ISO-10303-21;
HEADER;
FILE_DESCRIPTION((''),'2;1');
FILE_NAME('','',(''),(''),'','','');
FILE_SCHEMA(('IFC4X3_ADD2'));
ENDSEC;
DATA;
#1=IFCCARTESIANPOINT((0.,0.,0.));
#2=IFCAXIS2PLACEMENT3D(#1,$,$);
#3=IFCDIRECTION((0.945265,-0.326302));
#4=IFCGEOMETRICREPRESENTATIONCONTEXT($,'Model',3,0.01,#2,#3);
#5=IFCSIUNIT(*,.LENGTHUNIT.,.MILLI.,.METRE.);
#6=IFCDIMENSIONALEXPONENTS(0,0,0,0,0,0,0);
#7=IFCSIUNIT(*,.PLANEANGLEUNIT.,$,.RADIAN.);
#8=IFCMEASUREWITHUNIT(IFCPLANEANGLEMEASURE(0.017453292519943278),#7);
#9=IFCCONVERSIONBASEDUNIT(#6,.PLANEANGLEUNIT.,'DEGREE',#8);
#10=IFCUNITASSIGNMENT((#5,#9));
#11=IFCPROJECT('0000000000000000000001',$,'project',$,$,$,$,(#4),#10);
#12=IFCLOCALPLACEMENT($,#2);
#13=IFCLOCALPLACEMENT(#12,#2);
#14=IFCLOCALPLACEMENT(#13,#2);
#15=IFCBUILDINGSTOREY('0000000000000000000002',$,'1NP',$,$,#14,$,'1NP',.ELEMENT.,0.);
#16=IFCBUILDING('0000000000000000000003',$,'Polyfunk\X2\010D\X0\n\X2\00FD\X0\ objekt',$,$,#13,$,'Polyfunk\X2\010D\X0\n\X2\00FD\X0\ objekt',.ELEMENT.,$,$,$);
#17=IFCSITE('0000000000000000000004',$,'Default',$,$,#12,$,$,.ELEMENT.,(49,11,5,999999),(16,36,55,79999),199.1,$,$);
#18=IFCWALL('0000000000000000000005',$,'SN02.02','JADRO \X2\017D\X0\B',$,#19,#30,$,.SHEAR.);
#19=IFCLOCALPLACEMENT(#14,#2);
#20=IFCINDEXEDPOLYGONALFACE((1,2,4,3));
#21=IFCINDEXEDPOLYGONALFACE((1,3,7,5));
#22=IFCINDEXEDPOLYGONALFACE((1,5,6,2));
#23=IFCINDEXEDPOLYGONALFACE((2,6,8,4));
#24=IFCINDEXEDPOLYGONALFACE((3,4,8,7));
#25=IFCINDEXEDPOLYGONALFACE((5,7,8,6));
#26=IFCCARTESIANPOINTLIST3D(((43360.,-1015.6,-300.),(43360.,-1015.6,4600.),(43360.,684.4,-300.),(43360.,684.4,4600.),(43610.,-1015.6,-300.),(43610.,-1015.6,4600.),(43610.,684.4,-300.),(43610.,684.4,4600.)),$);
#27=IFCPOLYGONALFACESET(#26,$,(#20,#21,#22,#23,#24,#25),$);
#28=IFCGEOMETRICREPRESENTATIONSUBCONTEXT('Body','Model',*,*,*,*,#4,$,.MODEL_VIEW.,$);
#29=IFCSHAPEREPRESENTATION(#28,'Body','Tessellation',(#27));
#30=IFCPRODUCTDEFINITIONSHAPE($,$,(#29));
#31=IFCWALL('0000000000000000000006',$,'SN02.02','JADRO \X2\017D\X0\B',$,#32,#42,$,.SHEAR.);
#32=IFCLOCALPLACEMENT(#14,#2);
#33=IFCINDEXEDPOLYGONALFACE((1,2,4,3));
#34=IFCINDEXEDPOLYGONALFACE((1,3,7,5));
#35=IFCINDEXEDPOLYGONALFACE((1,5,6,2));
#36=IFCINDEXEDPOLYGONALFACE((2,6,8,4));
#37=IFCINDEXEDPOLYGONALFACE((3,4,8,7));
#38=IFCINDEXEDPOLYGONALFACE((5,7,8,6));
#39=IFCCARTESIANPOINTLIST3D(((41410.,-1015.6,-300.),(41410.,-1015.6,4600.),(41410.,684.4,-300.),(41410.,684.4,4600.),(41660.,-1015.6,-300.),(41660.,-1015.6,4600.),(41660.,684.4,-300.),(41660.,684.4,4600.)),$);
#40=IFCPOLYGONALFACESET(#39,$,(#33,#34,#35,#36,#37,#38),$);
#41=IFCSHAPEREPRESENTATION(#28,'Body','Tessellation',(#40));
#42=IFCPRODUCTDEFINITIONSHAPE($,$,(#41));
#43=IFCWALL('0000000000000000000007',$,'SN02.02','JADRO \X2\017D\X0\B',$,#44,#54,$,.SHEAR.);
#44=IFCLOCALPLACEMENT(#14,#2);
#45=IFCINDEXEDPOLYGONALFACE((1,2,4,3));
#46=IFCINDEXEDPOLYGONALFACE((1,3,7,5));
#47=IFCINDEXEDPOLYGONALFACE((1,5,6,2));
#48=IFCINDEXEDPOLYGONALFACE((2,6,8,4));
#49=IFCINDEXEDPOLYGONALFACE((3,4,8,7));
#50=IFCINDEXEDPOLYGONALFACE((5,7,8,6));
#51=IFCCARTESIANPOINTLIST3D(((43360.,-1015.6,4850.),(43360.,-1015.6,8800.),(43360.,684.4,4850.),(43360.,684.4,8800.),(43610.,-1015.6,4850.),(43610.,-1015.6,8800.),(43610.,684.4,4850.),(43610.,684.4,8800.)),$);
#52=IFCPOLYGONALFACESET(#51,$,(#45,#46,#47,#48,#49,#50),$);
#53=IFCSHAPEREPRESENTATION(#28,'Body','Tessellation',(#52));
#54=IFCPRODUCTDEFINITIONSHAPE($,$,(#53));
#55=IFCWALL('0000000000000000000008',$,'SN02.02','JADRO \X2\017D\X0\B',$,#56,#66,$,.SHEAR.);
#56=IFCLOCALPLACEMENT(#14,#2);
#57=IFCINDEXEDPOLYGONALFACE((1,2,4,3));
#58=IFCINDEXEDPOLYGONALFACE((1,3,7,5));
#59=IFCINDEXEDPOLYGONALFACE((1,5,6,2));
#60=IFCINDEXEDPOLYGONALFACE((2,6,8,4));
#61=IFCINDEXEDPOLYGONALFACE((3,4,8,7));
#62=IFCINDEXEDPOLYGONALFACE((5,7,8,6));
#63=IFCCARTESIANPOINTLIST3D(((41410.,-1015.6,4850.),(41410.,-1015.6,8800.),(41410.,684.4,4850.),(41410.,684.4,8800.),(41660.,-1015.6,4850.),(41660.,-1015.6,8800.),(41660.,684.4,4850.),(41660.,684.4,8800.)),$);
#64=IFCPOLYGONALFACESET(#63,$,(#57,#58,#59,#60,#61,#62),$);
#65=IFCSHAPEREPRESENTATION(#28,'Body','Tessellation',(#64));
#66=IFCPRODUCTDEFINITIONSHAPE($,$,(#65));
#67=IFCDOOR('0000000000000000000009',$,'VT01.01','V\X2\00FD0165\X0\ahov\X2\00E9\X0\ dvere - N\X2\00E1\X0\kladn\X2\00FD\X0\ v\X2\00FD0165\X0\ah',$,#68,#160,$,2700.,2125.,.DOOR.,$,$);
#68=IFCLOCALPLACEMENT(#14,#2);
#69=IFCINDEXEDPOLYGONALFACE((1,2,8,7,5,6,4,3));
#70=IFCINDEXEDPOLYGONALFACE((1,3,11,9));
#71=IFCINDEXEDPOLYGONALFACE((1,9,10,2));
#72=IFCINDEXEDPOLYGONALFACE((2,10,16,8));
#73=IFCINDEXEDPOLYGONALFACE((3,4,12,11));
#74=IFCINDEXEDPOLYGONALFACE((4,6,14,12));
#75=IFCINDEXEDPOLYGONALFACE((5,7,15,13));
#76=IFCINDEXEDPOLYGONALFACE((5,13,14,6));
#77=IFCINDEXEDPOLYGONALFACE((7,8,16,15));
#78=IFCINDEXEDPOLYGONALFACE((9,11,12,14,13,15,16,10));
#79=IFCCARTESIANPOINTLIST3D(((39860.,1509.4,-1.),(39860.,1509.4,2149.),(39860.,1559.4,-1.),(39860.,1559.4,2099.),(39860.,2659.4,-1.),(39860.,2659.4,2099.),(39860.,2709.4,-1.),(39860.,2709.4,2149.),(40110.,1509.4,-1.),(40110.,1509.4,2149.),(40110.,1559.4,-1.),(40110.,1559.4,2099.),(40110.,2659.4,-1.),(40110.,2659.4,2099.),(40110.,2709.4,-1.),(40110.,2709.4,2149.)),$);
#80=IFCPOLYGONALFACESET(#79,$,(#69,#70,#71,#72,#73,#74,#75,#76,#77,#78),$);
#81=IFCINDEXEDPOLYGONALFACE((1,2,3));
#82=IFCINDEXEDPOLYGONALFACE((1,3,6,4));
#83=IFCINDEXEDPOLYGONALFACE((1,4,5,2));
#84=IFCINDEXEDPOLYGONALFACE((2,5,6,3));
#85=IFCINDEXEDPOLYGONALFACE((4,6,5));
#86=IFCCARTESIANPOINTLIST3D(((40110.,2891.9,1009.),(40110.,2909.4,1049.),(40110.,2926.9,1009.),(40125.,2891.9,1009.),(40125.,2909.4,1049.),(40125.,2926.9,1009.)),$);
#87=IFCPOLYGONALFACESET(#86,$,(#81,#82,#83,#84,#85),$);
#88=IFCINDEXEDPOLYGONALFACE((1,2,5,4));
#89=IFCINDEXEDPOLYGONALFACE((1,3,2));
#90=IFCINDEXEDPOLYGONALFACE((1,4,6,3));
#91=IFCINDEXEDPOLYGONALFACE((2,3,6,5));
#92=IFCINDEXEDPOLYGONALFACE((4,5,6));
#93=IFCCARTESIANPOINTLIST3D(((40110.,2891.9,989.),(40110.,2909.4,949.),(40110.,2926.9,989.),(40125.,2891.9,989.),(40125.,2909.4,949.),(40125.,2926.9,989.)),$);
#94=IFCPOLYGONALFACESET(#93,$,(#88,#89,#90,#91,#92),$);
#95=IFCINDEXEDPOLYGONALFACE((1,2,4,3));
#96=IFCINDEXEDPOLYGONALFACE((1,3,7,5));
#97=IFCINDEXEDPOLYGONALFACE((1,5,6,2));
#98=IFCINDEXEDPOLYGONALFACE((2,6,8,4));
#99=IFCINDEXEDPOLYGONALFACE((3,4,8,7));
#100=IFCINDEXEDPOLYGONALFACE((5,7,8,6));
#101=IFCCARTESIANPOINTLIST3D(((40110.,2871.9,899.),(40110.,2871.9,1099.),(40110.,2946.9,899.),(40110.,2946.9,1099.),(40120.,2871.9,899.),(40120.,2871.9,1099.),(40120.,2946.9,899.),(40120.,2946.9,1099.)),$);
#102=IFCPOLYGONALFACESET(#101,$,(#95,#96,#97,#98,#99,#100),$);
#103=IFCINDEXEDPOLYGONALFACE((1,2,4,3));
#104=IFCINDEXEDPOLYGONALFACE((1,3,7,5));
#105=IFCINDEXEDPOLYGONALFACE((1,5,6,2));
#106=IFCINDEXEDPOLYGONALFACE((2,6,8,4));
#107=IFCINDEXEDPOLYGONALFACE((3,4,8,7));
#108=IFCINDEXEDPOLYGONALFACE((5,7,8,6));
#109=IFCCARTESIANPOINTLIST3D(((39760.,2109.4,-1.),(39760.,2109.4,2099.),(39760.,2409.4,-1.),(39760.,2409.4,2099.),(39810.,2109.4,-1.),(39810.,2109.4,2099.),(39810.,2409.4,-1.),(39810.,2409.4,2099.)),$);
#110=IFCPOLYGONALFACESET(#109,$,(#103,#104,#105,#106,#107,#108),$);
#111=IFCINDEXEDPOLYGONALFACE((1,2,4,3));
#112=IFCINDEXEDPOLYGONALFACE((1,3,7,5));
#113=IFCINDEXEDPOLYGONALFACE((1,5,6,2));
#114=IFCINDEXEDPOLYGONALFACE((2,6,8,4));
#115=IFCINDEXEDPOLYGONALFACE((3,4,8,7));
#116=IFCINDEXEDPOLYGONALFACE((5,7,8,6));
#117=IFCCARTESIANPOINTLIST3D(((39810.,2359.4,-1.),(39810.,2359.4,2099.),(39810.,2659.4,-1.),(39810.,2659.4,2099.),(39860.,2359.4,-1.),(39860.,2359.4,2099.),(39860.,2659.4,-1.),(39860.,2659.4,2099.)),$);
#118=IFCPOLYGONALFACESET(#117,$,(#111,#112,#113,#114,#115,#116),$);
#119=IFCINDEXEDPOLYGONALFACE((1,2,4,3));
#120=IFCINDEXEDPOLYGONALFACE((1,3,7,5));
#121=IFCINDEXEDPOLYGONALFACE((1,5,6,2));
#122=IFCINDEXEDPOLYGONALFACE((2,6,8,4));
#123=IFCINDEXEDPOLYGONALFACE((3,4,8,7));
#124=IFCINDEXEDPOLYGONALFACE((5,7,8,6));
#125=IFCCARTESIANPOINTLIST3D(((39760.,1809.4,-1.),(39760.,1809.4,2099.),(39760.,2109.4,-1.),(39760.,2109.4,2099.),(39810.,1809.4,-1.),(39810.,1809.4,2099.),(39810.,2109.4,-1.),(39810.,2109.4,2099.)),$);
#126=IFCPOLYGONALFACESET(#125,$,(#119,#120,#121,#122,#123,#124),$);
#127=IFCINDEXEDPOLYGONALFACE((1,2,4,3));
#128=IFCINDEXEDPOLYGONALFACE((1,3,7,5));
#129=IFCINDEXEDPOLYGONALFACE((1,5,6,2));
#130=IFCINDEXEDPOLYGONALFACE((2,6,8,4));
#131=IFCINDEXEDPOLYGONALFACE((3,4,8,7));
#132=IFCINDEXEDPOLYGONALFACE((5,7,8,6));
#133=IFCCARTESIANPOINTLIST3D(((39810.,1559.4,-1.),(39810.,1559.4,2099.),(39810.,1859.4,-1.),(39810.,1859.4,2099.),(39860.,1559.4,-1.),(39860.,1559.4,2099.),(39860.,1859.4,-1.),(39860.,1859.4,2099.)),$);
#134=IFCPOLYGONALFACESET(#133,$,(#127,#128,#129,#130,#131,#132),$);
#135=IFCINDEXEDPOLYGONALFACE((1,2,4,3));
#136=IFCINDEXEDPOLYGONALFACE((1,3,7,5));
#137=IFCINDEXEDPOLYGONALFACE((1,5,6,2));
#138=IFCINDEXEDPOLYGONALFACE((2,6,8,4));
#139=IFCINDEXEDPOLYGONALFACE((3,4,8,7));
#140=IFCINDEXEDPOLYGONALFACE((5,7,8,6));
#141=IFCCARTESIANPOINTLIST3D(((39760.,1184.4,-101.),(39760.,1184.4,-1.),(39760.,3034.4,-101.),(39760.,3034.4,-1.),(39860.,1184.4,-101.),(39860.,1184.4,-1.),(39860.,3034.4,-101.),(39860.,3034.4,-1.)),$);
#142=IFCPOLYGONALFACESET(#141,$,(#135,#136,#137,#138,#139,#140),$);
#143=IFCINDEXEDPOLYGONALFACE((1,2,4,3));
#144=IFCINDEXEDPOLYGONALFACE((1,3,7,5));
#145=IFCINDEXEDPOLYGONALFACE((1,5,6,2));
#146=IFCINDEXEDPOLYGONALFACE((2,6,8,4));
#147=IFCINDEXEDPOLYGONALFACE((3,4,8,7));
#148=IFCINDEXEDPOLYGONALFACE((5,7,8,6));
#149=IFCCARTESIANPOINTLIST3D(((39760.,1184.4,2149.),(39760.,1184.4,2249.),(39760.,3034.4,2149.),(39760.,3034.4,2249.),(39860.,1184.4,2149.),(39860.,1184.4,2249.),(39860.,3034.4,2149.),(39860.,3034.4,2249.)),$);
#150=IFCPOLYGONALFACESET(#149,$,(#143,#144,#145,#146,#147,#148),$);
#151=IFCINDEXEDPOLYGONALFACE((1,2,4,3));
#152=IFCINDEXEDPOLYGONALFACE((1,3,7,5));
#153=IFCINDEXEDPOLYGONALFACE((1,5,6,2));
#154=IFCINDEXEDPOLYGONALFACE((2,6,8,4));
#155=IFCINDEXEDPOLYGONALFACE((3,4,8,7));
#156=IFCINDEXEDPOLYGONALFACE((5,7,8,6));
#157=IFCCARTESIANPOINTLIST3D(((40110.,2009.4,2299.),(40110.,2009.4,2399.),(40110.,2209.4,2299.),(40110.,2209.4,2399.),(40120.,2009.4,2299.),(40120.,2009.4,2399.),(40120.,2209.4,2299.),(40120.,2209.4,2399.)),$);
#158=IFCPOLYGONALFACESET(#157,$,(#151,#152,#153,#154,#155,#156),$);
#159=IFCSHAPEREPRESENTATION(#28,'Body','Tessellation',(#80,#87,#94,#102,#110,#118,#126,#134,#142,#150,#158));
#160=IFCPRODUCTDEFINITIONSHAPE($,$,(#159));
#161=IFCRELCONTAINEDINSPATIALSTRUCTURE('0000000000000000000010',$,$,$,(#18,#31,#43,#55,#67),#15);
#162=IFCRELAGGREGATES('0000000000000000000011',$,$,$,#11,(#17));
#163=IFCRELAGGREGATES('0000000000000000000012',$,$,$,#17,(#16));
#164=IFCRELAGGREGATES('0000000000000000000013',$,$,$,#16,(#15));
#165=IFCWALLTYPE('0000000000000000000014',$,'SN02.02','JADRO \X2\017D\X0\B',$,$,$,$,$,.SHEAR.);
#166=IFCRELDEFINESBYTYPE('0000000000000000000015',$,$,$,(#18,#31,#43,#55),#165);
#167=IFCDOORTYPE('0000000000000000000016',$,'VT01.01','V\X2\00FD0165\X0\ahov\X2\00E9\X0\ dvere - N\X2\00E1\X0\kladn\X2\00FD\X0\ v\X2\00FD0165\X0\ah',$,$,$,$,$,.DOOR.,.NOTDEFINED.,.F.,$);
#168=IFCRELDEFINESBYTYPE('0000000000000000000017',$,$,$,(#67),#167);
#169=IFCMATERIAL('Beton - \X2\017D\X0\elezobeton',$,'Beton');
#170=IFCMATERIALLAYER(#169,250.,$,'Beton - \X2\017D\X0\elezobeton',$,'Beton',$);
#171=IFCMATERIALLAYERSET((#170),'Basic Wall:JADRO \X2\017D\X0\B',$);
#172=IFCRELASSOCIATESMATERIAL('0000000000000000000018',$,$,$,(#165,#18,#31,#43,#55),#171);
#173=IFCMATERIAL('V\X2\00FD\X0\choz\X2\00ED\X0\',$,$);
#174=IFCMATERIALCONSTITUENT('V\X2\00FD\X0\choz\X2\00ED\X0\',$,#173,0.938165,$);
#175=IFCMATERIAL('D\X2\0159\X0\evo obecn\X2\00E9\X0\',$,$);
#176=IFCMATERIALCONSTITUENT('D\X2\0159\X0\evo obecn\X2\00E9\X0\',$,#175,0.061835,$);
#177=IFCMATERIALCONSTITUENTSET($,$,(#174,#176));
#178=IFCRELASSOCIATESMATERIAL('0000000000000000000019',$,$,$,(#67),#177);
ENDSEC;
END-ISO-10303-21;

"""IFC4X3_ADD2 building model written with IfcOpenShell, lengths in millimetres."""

from ifc_helpers import new_model, entity, si_unit, converted_unit, direction, frame, frame_2d, origin, origin_2d_with_axis, place, context, subcontext, project, spatial, polyline, rectangle, outline, extrude, clip, bounded_halfspace, source, transform, mapped, material, layer, layer_set, constituent, constituent_set, type_object, type_shapes, element, save


model = new_model("IFC4X3_ADD2")

# Units and contexts
model_context = context("Model", 3, precision=0.01, world=origin(), true_north=direction((0.945265, -0.326302)))
body_context = subcontext(model_context, "Body", "Model", "MODEL_VIEW")
ifc_project = project(units=[si_unit("LENGTHUNIT", "METRE", prefix="MILLI"), converted_unit("PLANEANGLEUNIT", "DEGREE", entity("IfcPlaneAngleMeasure", 0.017453292519943278), si_unit("PLANEANGLEUNIT", "RADIAN"), dimensions=[0, 0, 0, 0, 0, 0, 0])], contexts=[model_context])

# Site, building, storey
site_placement = place(None, origin())
site = spatial("IfcSite", under=ifc_project, at=site_placement, Name="Default", CompositionType="ELEMENT", RefLatitude=(49, 11, 5, 999999), RefLongitude=(16, 36, 55, 79999), RefElevation=199.1)
building_placement = place(site_placement, origin())
building = spatial("IfcBuilding", under=site, at=building_placement, Name="Polyfunkčný objekt", LongName="Polyfunkčný objekt", CompositionType="ELEMENT")
storey_placement = place(building_placement, origin())
storey = spatial("IfcBuildingStorey", under=building, at=storey_placement, Name="1NP", LongName="1NP", CompositionType="ELEMENT", Elevation=0.0)

# Shared definitions
ifc_material_1 = material(Name="Beton - Železobeton", Category="Beton")

# Walls
ifc_layer_1 = layer(ifc_material_1, 250.0, Name="Beton - Železobeton", Category="Beton")
ifc_layer_set_1 = layer_set([ifc_layer_1], Name="Basic Wall:JADRO ŽB")
wall_type = type_object("IfcWallType", Name="SN02.02", Description="JADRO ŽB", PredefinedType="SHEAR", material=ifc_layer_set_1)
wall_1_placement = place(storey_placement, frame((43485.0, 684.4, -300.0), z_axis=(0.0, 0.0, 1.0), x_axis=(0.0, -1.0, 0.0)))
element("IfcWall", 1, at=wall_1_placement, inside=storey, type_object=wall_type, material=ifc_layer_set_1, Name="SN02.02", Description="JADRO ŽB", PredefinedType="SHEAR", context=body_context, shape_type="Clipping", body=[
    clip(clip(extrude(rectangle(XDim=1700.0, YDim=250.0, at=frame_2d((850.0, 0.0), x_axis=(-1.0, 0.0))), origin(), (0.0, 0.0, 1.0), 4900.0), bounded_halfspace(frame((0.0, -125.0, 4900.0), z_axis=(0.0, 0.0, -1.0), x_axis=(0.0, 1.0, 0.0)), True, frame((0.0, -125.0, 4900.0)), polyline([(0.0, 0.0), (1700.0, 0.0), (1700.0, 250.0), (0.0, 250.0), (0.0, 0.0)]))), bounded_halfspace(frame((1700.0, -125.0, 0.0), z_axis=(0.0, 0.0, 1.0), x_axis=(-1.0, 0.0, 0.0)), True, frame((1700.0, -125.0, 0.0)), polyline([(0.0, 0.0), (0.0, 250.0), (-1700.0, 250.0), (-1700.0, 0.0), (0.0, 0.0)]))),
])
wall_2_placement = place(storey_placement, frame((41535.0, 684.4, -300.0), z_axis=(0.0, 0.0, 1.0), x_axis=(0.0, -1.0, 0.0)))
element("IfcWall", 2, at=wall_2_placement, inside=storey, type_object=wall_type, material=ifc_layer_set_1, Name="SN02.02", Description="JADRO ŽB", PredefinedType="SHEAR", context=body_context, shape_type="Clipping", body=[
    clip(clip(extrude(rectangle(XDim=1700.0, YDim=250.0, at=frame_2d((850.0, 0.0), x_axis=(-1.0, 0.0))), origin(), (0.0, 0.0, 1.0), 4900.0), bounded_halfspace(frame((0.0, -125.0, 4900.0), z_axis=(0.0, 0.0, -1.0), x_axis=(0.0, 1.0, 0.0)), True, frame((0.0, -125.0, 4900.0)), polyline([(0.0, 0.0), (1700.0, 0.0), (1700.0, 250.0), (0.0, 250.0), (0.0, 0.0)]))), bounded_halfspace(frame((1700.0, -125.0, 0.0), z_axis=(0.0, 0.0, 1.0), x_axis=(-1.0, 0.0, 0.0)), True, frame((1700.0, -125.0, 0.0)), polyline([(0.0, 0.0), (0.0, 250.0), (-1700.0, 250.0), (-1700.0, 0.0), (0.0, 0.0)]))),
])
wall_3_placement = place(storey_placement, frame((43485.0, 684.4, 4850.0), z_axis=(0.0, 0.0, 1.0), x_axis=(0.0, -1.0, 0.0)))
element("IfcWall", 3, at=wall_3_placement, inside=storey, type_object=wall_type, material=ifc_layer_set_1, Name="SN02.02", Description="JADRO ŽB", PredefinedType="SHEAR", context=body_context, shape_type="Clipping", body=[
    clip(clip(extrude(rectangle(XDim=1700.0, YDim=250.0, at=frame_2d((850.0, 0.0), x_axis=(-1.0, 0.0))), origin(), (0.0, 0.0, 1.0), 3950.0), bounded_halfspace(frame((1700.0, -125.0, 0.0), z_axis=(0.0, 0.0, 1.0), x_axis=(0.0, -1.0, 0.0)), True, frame((1700.0, -125.0, 0.0)), polyline([(0.0, 0.0), (0.0, 250.0), (-1700.0, 250.0), (-1700.0, 0.0), (0.0, 0.0)]))), bounded_halfspace(frame((0.0, -125.0, 3950.0), z_axis=(0.0, 0.0, -1.0), x_axis=(0.0, 1.0, 0.0)), True, frame((0.0, -125.0, 3950.0)), polyline([(0.0, 0.0), (1700.0, 0.0), (1700.0, 250.0), (0.0, 250.0), (0.0, 0.0)]))),
])
wall_4_placement = place(storey_placement, frame((41535.0, 684.4, 4850.0), z_axis=(0.0, 0.0, 1.0), x_axis=(0.0, -1.0, 0.0)))
element("IfcWall", 4, at=wall_4_placement, inside=storey, type_object=wall_type, material=ifc_layer_set_1, Name="SN02.02", Description="JADRO ŽB", PredefinedType="SHEAR", context=body_context, shape_type="Clipping", body=[
    clip(clip(extrude(rectangle(XDim=1700.0, YDim=250.0, at=frame_2d((850.0, 0.0), x_axis=(-1.0, 0.0))), origin(), (0.0, 0.0, 1.0), 3950.0), bounded_halfspace(frame((1700.0, -125.0, 0.0), z_axis=(0.0, 0.0, 1.0), x_axis=(0.0, -1.0, 0.0)), True, frame((1700.0, -125.0, 0.0)), polyline([(0.0, 0.0), (0.0, 250.0), (-1700.0, 250.0), (-1700.0, 0.0), (0.0, 0.0)]))), bounded_halfspace(frame((0.0, -125.0, 3950.0), z_axis=(0.0, 0.0, -1.0), x_axis=(0.0, 1.0, 0.0)), True, frame((0.0, -125.0, 3950.0)), polyline([(0.0, 0.0), (1700.0, 0.0), (1700.0, 250.0), (0.0, 250.0), (0.0, 0.0)]))),
])

# Door
ifc_material_2 = material(Name="Výchozí")
ifc_material_3 = material(Name="Dřevo obecné")
ifc_constituent_1 = constituent(ifc_material_2, Name="Výchozí", fraction=0.938165)
ifc_constituent_2 = constituent(ifc_material_3, Name="Dřevo obecné", fraction=0.061835)
ifc_constituent_set_1 = constituent_set(constituents=[ifc_constituent_1, ifc_constituent_2])
door_type_1 = type_object("IfcDoorType", Name="VT01.01", Description="Výťahové dvere - Nákladný výťah", OperationType="NOTDEFINED", ParameterTakesPrecedence=False, PredefinedType="DOOR")
shared_shape_1 = source(origin(), body_context, "Body", "SweptSolid", [
    extrude(outline(polyline([(-1087.5, -600.0), (1062.5, -600.0), (1062.5, -550.0), (-1037.5, -550.0), (-1037.5, 550.0), (1062.5, 550.0), (1062.5, 600.0), (-1087.5, 600.0), (-1087.5, -600.0)])), frame((600.0, 0.0, 1062.5), z_axis=(0.0, 1.0, 0.0), x_axis=(0.0, 0.0, -1.0)), (0.0, 0.0, 1.0), 250.0),
    extrude(outline(polyline([(-24.4, -10.7), (19.2, -10.7), (5.2, 21.4), (-24.4, -10.7)])), frame((1400.0, -15.0, 1023.3), z_axis=(0.0, 1.0, 0.0), x_axis=(0.400819, 0.0, -0.916157)), (0.0, 0.0, 1.0), 15.0),
    extrude(outline(polyline([(-24.4, -10.7), (19.2, -10.7), (5.2, 21.4), (-24.4, -10.7)])), frame((1400.0, -15.0, 976.7), z_axis=(0.0, 1.0, 0.0), x_axis=(-0.400819, 0.0, 0.916157)), (0.0, 0.0, 1.0), 15.0),
    extrude(rectangle(XDim=10.0, YDim=75.0, at=frame_2d((0.0, 0.0), x_axis=(1.0, 0.0))), frame((1400.0, -5.0, 900.0), z_axis=(0.0, 0.0, 1.0), x_axis=(0.0, 1.0, 0.0)), (0.0, 0.0, 1.0), 200.0),
    extrude(rectangle(XDim=50.0, YDim=300.0, at=origin_2d_with_axis()), frame((750.0, 325.0, 0.0), z_axis=(0.0, 0.0, 1.0), x_axis=(0.0, -1.0, 0.0)), (0.0, 0.0, 1.0), 2100.0),
    extrude(rectangle(XDim=50.0, YDim=300.0, at=frame_2d((0.0, 0.0), x_axis=(1.0, 0.0))), frame((1000.0, 275.0, 0.0), z_axis=(0.0, 0.0, 1.0), x_axis=(0.0, -1.0, 0.0)), (0.0, 0.0, 1.0), 2100.0),
    extrude(rectangle(XDim=300.0, YDim=50.0, at=frame_2d((0.0, 0.0), x_axis=(1.0, 0.0))), frame((450.0, 325.0, 0.0), z_axis=(0.0, 0.0, 1.0), x_axis=(-1.0, 0.0, 0.0)), (0.0, 0.0, 1.0), 2100.0),
    extrude(rectangle(XDim=300.0, YDim=50.0, at=frame_2d((0.0, 0.0), x_axis=(1.0, 0.0))), frame((200.0, 275.0, 0.0), z_axis=(0.0, 0.0, 1.0), x_axis=(-1.0, 0.0, 0.0)), (0.0, 0.0, 1.0), 2100.0),
    extrude(rectangle(XDim=1850.0, YDim=100.0, at=frame_2d((0.0, 0.0), x_axis=(1.0, 0.0))), frame((600.0, 300.0, -100.0), z_axis=(0.0, 0.0, 1.0), x_axis=(-1.0, 0.0, 0.0)), (0.0, 0.0, 1.0), 100.0),
    extrude(rectangle(XDim=1850.0, YDim=100.0, at=frame_2d((0.0, 0.0), x_axis=(1.0, 0.0))), frame((600.0, 300.0, 2150.0), z_axis=(0.0, 0.0, 1.0), x_axis=(-1.0, 0.0, 0.0)), (0.0, 0.0, 1.0), 100.0),
    extrude(rectangle(XDim=10.0, YDim=200.0, at=frame_2d((0.0, 0.0), x_axis=(1.0, 0.0))), frame((600.0, -5.0, 2300.0), z_axis=(0.0, 0.0, 1.0), x_axis=(0.0, 1.0, 0.0)), (0.0, 0.0, 1.0), 100.0),
])
type_shapes(door_type_1, [shared_shape_1])
door_1_placement = place(storey_placement, frame((40110.0, 1509.4, -1.0), z_axis=(0.0, 0.0, 1.0), x_axis=(0.0, 1.0, 0.0)))
element("IfcDoor", 5, at=door_1_placement, inside=storey, type_object=door_type_1, material=ifc_constituent_set_1, Name="VT01.01", Description="Výťahové dvere - Nákladný výťah", OverallHeight=2700.0, OverallWidth=2125.0, PredefinedType="DOOR", context=body_context, shape_type="MappedRepresentation", body=[
    mapped(shared_shape_1, transform((0.0, 0.0, 0.0), scale=1.0)),
])

save(model, "model.ifc")
